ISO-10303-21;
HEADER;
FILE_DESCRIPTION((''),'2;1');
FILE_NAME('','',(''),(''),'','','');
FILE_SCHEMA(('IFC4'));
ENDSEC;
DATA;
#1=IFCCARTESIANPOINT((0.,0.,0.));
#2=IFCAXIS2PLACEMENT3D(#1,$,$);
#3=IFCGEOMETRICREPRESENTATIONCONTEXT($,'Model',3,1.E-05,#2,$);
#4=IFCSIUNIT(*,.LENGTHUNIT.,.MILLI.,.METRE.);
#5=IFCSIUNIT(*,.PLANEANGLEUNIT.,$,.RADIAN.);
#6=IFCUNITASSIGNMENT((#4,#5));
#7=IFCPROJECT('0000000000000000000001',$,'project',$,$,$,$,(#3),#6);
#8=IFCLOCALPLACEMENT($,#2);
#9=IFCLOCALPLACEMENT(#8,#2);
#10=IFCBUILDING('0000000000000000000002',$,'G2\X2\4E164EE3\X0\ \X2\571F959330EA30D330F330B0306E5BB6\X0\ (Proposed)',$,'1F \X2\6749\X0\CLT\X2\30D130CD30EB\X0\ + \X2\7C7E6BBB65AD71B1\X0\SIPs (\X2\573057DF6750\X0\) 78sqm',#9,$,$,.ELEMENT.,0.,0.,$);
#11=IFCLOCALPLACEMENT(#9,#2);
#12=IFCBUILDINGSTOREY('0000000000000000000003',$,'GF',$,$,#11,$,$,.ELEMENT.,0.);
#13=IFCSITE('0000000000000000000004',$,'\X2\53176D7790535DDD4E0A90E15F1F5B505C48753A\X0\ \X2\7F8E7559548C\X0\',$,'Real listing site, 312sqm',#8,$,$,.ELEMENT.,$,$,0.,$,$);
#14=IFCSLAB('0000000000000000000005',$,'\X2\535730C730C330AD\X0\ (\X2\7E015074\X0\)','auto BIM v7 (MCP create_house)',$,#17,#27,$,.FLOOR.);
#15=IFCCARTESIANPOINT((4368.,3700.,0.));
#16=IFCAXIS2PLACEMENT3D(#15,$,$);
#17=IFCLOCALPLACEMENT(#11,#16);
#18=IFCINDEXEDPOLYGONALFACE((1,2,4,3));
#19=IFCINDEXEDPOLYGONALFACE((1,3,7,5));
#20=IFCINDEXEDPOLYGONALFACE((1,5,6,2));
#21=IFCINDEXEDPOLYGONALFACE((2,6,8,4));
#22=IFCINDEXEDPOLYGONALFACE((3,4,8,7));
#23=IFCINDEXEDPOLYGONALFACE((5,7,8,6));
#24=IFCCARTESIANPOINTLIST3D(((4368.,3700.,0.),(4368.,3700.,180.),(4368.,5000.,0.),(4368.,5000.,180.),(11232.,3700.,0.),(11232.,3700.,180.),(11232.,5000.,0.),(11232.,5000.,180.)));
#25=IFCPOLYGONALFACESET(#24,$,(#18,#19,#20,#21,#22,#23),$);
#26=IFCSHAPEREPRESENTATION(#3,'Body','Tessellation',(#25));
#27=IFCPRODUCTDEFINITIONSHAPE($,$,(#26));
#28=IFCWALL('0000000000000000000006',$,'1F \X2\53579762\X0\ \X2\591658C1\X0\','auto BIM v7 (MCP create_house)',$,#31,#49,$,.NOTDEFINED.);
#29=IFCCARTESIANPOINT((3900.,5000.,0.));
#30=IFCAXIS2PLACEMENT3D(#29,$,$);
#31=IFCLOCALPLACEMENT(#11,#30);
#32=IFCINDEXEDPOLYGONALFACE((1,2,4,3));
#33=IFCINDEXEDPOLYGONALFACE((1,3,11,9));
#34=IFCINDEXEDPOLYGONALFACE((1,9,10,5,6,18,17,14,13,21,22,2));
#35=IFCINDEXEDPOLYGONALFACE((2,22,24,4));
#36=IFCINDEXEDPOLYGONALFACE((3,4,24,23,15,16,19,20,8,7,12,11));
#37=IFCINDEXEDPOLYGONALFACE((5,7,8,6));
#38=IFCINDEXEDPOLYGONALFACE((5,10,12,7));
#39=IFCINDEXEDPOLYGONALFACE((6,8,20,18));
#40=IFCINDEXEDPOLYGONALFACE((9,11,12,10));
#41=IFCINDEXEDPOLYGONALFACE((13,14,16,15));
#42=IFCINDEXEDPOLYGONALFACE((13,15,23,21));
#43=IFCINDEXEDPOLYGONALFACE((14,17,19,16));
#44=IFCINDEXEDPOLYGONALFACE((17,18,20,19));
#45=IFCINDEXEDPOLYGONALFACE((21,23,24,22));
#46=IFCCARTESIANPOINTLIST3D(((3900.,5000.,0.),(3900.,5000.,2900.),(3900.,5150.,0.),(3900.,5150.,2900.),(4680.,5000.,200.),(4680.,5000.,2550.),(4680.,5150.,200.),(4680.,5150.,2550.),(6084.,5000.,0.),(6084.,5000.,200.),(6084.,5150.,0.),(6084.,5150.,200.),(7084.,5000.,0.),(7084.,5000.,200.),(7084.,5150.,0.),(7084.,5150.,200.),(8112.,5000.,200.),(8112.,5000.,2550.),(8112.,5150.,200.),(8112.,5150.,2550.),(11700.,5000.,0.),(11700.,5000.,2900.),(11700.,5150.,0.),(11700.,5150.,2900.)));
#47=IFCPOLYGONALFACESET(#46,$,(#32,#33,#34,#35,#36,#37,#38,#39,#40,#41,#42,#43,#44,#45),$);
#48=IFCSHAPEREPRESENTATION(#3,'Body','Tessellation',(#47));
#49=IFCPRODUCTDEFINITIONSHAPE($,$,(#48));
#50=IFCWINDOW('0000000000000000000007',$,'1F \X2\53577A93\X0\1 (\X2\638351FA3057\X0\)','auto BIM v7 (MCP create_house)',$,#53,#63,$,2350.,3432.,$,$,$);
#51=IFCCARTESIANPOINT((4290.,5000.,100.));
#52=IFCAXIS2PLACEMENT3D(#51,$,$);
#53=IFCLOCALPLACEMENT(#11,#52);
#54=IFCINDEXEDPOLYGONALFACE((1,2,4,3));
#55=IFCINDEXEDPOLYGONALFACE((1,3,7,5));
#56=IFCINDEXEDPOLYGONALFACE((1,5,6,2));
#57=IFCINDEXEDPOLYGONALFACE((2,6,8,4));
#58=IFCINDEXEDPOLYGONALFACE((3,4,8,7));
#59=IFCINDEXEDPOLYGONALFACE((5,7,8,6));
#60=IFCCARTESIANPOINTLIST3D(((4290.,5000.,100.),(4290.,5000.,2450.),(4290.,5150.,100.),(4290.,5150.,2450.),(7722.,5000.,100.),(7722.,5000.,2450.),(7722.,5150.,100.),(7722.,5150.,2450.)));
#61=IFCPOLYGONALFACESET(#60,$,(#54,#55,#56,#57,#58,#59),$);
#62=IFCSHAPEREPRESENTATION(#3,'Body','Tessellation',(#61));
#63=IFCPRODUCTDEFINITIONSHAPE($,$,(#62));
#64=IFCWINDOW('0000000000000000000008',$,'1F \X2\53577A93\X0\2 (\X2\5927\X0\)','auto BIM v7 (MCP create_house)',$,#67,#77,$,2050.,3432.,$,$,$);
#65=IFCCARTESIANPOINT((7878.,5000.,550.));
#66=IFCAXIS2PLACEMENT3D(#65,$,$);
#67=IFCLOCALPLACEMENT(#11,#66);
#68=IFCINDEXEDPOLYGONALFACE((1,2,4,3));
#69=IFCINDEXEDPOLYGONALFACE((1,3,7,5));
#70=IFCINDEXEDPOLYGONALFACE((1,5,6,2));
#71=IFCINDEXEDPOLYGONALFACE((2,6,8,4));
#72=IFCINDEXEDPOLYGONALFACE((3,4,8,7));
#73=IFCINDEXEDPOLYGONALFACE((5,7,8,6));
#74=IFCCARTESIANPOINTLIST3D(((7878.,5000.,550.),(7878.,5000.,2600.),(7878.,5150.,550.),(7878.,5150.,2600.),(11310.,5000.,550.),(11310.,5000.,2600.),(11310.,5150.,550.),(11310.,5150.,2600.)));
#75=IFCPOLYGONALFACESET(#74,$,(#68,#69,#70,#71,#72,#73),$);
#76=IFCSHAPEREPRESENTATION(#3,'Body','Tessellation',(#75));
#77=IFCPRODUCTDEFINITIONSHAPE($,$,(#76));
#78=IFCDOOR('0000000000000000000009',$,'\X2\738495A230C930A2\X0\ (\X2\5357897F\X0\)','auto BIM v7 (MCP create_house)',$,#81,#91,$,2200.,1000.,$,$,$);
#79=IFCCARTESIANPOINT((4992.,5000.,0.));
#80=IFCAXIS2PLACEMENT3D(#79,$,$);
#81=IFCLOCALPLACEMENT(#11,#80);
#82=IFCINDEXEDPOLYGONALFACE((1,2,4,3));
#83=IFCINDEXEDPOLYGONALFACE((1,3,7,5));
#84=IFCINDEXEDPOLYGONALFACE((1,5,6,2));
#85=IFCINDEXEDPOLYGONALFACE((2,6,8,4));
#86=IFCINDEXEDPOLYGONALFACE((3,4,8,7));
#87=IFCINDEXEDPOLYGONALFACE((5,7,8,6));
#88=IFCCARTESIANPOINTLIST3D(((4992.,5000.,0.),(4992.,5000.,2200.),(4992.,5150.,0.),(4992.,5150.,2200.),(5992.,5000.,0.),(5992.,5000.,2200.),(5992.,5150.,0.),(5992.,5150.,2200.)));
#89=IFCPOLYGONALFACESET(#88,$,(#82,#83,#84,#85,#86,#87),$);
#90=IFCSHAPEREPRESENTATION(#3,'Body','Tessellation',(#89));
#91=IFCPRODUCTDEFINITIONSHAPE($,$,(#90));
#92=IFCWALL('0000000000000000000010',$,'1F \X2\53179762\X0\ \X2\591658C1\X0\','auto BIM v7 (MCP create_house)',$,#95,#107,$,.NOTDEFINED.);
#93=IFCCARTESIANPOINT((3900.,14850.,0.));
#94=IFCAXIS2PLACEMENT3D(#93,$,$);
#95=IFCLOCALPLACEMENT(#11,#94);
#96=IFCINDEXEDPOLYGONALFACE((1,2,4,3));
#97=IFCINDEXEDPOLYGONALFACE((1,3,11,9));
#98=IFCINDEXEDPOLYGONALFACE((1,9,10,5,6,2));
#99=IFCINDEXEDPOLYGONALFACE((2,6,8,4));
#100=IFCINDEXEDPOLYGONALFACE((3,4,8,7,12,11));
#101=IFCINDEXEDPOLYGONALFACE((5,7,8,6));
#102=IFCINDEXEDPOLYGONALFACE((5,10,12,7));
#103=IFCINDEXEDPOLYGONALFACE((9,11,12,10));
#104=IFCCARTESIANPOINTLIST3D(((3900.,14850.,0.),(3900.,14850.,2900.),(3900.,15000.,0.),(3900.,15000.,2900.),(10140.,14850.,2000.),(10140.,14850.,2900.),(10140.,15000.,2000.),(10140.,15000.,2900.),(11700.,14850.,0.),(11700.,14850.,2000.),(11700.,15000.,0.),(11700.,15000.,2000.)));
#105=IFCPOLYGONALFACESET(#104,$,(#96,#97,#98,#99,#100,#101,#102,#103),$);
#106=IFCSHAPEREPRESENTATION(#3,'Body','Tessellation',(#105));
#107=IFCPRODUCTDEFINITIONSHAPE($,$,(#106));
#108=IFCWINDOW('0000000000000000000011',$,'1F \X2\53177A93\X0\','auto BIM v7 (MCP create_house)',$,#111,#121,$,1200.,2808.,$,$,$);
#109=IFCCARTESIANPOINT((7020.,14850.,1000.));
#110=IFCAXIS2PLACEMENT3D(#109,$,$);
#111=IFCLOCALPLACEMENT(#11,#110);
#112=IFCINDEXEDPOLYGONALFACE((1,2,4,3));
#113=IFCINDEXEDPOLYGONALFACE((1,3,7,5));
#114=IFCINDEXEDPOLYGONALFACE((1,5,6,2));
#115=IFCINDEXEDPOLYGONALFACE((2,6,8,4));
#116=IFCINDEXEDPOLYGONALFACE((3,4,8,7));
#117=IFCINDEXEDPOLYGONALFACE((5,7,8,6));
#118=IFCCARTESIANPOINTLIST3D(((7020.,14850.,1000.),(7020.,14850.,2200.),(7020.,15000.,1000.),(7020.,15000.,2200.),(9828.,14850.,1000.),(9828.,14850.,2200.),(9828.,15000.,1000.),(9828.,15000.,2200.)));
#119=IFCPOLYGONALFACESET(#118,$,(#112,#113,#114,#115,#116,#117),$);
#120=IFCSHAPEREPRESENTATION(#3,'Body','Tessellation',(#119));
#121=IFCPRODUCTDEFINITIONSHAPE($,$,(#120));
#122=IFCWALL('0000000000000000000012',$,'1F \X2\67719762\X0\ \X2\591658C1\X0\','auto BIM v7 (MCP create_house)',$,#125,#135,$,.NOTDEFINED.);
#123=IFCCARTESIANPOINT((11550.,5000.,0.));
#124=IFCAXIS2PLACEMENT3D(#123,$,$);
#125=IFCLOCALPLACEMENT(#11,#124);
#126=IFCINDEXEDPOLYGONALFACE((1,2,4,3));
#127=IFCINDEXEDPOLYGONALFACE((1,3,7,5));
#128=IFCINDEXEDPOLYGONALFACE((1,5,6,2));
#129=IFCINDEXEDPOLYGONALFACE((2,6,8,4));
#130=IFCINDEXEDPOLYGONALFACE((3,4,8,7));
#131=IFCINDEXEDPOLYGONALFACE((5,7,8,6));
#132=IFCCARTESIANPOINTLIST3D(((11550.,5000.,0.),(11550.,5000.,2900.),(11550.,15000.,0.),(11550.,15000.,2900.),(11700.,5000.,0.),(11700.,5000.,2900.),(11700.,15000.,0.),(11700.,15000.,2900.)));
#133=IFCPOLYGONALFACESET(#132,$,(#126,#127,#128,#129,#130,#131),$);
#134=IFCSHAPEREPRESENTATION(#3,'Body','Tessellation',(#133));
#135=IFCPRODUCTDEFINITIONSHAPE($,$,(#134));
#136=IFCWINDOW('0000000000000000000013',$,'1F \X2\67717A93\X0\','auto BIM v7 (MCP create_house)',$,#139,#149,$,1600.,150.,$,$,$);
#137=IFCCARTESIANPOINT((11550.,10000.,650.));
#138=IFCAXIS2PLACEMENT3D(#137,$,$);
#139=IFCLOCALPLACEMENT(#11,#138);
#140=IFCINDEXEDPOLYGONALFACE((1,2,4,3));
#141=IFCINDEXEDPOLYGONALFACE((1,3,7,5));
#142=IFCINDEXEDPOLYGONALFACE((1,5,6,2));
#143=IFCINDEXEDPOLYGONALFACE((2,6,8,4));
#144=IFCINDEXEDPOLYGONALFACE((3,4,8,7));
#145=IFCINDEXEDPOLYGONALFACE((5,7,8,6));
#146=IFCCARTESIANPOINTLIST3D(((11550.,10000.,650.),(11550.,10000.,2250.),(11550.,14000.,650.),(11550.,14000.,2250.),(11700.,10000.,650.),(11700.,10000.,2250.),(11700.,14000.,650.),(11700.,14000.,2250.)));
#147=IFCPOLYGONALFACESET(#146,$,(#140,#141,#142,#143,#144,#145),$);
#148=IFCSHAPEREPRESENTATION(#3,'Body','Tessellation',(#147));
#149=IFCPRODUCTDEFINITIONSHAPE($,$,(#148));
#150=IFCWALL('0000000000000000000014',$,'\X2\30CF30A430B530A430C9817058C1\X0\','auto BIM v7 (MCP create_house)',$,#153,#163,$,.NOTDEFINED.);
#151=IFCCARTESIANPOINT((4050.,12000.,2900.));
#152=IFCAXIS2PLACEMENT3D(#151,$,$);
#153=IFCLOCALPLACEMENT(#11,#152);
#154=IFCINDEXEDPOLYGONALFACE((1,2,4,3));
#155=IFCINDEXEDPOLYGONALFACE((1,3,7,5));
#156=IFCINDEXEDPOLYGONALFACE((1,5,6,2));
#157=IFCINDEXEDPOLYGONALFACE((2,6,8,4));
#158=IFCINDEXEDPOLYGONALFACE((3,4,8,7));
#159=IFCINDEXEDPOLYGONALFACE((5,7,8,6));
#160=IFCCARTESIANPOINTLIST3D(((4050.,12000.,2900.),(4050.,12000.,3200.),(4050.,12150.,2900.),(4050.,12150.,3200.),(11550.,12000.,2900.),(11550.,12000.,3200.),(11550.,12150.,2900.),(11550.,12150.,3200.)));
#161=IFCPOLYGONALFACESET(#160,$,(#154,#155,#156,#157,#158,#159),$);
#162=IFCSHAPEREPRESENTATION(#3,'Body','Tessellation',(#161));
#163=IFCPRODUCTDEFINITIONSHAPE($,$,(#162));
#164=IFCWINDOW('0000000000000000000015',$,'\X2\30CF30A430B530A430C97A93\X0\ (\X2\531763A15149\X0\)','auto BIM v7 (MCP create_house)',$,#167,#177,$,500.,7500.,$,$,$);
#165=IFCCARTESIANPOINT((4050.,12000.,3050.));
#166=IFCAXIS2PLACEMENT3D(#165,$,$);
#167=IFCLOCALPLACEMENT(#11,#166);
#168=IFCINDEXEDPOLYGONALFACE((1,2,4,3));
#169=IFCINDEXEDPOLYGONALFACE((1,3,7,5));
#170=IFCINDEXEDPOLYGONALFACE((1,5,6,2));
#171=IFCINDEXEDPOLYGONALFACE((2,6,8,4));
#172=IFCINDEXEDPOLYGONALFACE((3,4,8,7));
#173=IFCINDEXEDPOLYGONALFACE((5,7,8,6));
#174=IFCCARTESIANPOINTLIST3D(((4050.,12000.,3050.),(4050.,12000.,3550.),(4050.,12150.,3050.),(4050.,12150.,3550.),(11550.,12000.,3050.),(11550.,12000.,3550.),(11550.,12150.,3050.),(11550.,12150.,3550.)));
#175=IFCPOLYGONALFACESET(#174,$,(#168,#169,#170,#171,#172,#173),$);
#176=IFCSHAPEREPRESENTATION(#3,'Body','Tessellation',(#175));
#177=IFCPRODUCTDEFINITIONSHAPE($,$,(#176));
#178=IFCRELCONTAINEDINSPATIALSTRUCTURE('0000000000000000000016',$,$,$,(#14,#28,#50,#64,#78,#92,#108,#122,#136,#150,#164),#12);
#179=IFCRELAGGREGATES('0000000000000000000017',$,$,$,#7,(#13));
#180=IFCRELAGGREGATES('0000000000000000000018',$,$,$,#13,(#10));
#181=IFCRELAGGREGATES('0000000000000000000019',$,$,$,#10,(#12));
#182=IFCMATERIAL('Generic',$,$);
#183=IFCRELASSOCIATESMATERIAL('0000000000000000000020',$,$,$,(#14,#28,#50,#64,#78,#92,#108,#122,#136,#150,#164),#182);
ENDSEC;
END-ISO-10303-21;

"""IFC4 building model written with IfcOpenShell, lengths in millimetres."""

from ifc_helpers import new_model, si_unit, frame, frame_2d, origin, place, context, project, spatial, rectangle, extrude, material, element, fill, save


model = new_model("IFC4")

# Units and contexts
model_context = context("Model", 3, precision=1e-05, world=origin())
ifc_project = project(units=[si_unit("LENGTHUNIT", "METRE", prefix="MILLI"), si_unit("PLANEANGLEUNIT", "RADIAN")], contexts=[model_context])

# Site, building, storey
site_placement = place(None, origin())
site = spatial("IfcSite", under=ifc_project, at=site_placement, Name="北海道川上郡弟子屈町 美留和", ObjectType="Real listing site, 312sqm", CompositionType="ELEMENT", RefElevation=0.0)
building_placement = place(site_placement, origin())
building = spatial("IfcBuilding", under=site, at=building_placement, Name="G2世代 土間リビングの家 (Proposed)", ObjectType="1F 杉CLTパネル + 籾殻断熱SIPs (地域材) 78sqm", CompositionType="ELEMENT", ElevationOfRefHeight=0.0, ElevationOfTerrain=0.0)
storey_placement = place(building_placement, origin())
storey = spatial("IfcBuildingStorey", under=building, at=storey_placement, Name="GF", CompositionType="ELEMENT", Elevation=0.0)

# Slab
ifc_material = material(Name="Generic")
slab_1_placement = place(storey_placement, frame((4368.0, 3700.0, 0.0)))
element("IfcSlab", 1, at=slab_1_placement, inside=storey, material=ifc_material, Name="南デッキ (縁側)", Description="auto BIM v7 (MCP create_house)", PredefinedType="FLOOR", context=model_context, shape_type="SweptSolid", body=[
    extrude(rectangle(XDim=6864.0, YDim=1300.0, at=frame_2d((3432.0, 650.0))), frame((4368.0, 3700.0, 0.0)), (0.0, 0.0, 1.0), 180.0),
])

# Wall, openings, windows, door
wall_1_placement = place(storey_placement, frame((3900.0, 5000.0, 0.0)))
wall_1 = element("IfcWall", 2, at=wall_1_placement, inside=storey, material=ifc_material, Name="1F 南面 外壁", Description="auto BIM v7 (MCP create_house)", PredefinedType="NOTDEFINED", context=model_context, shape_type="SweptSolid", body=[
    extrude(rectangle(XDim=7800.0, YDim=150.0, at=frame_2d((3900.0, 75.0))), frame((3900.0, 5000.0, 0.0)), (0.0, 0.0, 1.0), 2900.0),
])
opening_1_placement = place(storey_placement, frame((4290.0, 5000.0, 100.0)))
opening_1 = element("IfcOpeningElement", 3, at=opening_1_placement, cuts=wall_1, PredefinedType="NOTDEFINED", context=model_context, shape_type="SweptSolid", body=[
    extrude(rectangle(XDim=3432.0, YDim=150.0, at=frame_2d((1716.0, 75.0))), frame((4290.0, 5000.0, 100.0)), (0.0, 0.0, 1.0), 2350.0),
])
opening_2_placement = place(storey_placement, frame((7878.0, 5000.0, 550.0)))
opening_2 = element("IfcOpeningElement", 4, at=opening_2_placement, cuts=wall_1, PredefinedType="NOTDEFINED", context=model_context, shape_type="SweptSolid", body=[
    extrude(rectangle(XDim=3432.0, YDim=150.0, at=frame_2d((1716.0, 75.0))), frame((7878.0, 5000.0, 550.0)), (0.0, 0.0, 1.0), 2050.0),
])
opening_3_placement = place(storey_placement, frame((4992.0, 5000.0, 0.0)))
opening_3 = element("IfcOpeningElement", 5, at=opening_3_placement, cuts=wall_1, PredefinedType="NOTDEFINED", context=model_context, shape_type="SweptSolid", body=[
    extrude(rectangle(XDim=1000.0, YDim=150.0, at=frame_2d((500.0, 75.0))), frame((4992.0, 5000.0, 0.0)), (0.0, 0.0, 1.0), 2200.0),
])
window_1_placement = place(storey_placement, frame((4290.0, 5000.0, 100.0)))
window_1 = element("IfcWindow", 6, at=window_1_placement, inside=storey, material=ifc_material, Name="1F 南窓1 (掃出し)", Description="auto BIM v7 (MCP create_house)", OverallHeight=2350.0, OverallWidth=3432.0, context=model_context, shape_type="SweptSolid", body=[
    extrude(rectangle(XDim=3432.0, YDim=150.0, at=frame_2d((1716.0, 75.0))), frame((4290.0, 5000.0, 100.0)), (0.0, 0.0, 1.0), 2350.0),
])
fill(opening_1, window_1)
window_2_placement = place(storey_placement, frame((7878.0, 5000.0, 550.0)))
window_2 = element("IfcWindow", 7, at=window_2_placement, inside=storey, material=ifc_material, Name="1F 南窓2 (大)", Description="auto BIM v7 (MCP create_house)", OverallHeight=2050.0, OverallWidth=3432.0, context=model_context, shape_type="SweptSolid", body=[
    extrude(rectangle(XDim=3432.0, YDim=150.0, at=frame_2d((1716.0, 75.0))), frame((7878.0, 5000.0, 550.0)), (0.0, 0.0, 1.0), 2050.0),
])
fill(opening_2, window_2)
door_placement = place(storey_placement, frame((4992.0, 5000.0, 0.0)))
door = element("IfcDoor", 8, at=door_placement, inside=storey, material=ifc_material, Name="玄関ドア (南西)", Description="auto BIM v7 (MCP create_house)", OverallHeight=2200.0, OverallWidth=1000.0, context=model_context, shape_type="SweptSolid", body=[
    extrude(rectangle(XDim=1000.0, YDim=150.0, at=frame_2d((500.0, 75.0))), frame((4992.0, 5000.0, 0.0)), (0.0, 0.0, 1.0), 2200.0),
])
fill(opening_3, door)

# Walls, openings, windows
wall_2_placement = place(storey_placement, frame((3900.0, 14850.0, 0.0)))
wall_2 = element("IfcWall", 9, at=wall_2_placement, inside=storey, material=ifc_material, Name="1F 北面 外壁", Description="auto BIM v7 (MCP create_house)", PredefinedType="NOTDEFINED", context=model_context, shape_type="SweptSolid", body=[
    extrude(rectangle(XDim=7800.0, YDim=150.0, at=frame_2d((3900.0, 75.0))), frame((3900.0, 14850.0, 0.0)), (0.0, 0.0, 1.0), 2900.0),
])
opening_4_placement = place(storey_placement, frame((7020.0, 14850.0, 1000.0)))
opening_4 = element("IfcOpeningElement", 10, at=opening_4_placement, cuts=wall_2, PredefinedType="NOTDEFINED", context=model_context, shape_type="SweptSolid", body=[
    extrude(rectangle(XDim=2808.0, YDim=150.0, at=frame_2d((1404.0, 75.0))), frame((7020.0, 14850.0, 1000.0)), (0.0, 0.0, 1.0), 1200.0),
])
window_3_placement = place(storey_placement, frame((7020.0, 14850.0, 1000.0)))
window_3 = element("IfcWindow", 11, at=window_3_placement, inside=storey, material=ifc_material, Name="1F 北窓", Description="auto BIM v7 (MCP create_house)", OverallHeight=1200.0, OverallWidth=2808.0, context=model_context, shape_type="SweptSolid", body=[
    extrude(rectangle(XDim=2808.0, YDim=150.0, at=frame_2d((1404.0, 75.0))), frame((7020.0, 14850.0, 1000.0)), (0.0, 0.0, 1.0), 1200.0),
])
fill(opening_4, window_3)
wall_3_placement = place(storey_placement, frame((11550.0, 5000.0, 0.0)))
wall_3 = element("IfcWall", 12, at=wall_3_placement, inside=storey, material=ifc_material, Name="1F 東面 外壁", Description="auto BIM v7 (MCP create_house)", PredefinedType="NOTDEFINED", context=model_context, shape_type="SweptSolid", body=[
    extrude(rectangle(XDim=150.0, YDim=10000.0, at=frame_2d((75.0, 5000.0))), frame((11550.0, 5000.0, 0.0)), (0.0, 0.0, 1.0), 2900.0),
])
opening_5_placement = place(storey_placement, frame((11550.0, 10000.0, 650.0)))
opening_5 = element("IfcOpeningElement", 13, at=opening_5_placement, cuts=wall_3, PredefinedType="NOTDEFINED", context=model_context, shape_type="SweptSolid", body=[
    extrude(rectangle(XDim=150.0, YDim=4000.0, at=frame_2d((75.0, 2000.0))), frame((11550.0, 10000.0, 650.0)), (0.0, 0.0, 1.0), 1600.0),
])
window_4_placement = place(storey_placement, frame((11550.0, 10000.0, 650.0)))
window_4 = element("IfcWindow", 14, at=window_4_placement, inside=storey, material=ifc_material, Name="1F 東窓", Description="auto BIM v7 (MCP create_house)", OverallHeight=1600.0, OverallWidth=150.0, context=model_context, shape_type="SweptSolid", body=[
    extrude(rectangle(XDim=150.0, YDim=4000.0, at=frame_2d((75.0, 2000.0))), frame((11550.0, 10000.0, 650.0)), (0.0, 0.0, 1.0), 1600.0),
])
fill(opening_5, window_4)

# Wall, opening, window
wall_4_placement = place(storey_placement, frame((4050.0, 12000.0, 2900.0)))
wall_4 = element("IfcWall", 15, at=wall_4_placement, inside=storey, material=ifc_material, Name="ハイサイド腰壁", Description="auto BIM v7 (MCP create_house)", PredefinedType="NOTDEFINED", context=model_context, shape_type="SweptSolid", body=[
    extrude(rectangle(XDim=7500.0, YDim=150.0, at=frame_2d((3750.0, 75.0))), frame((4050.0, 12000.0, 2900.0)), (0.0, 0.0, 1.0), 700.0),
])
opening_6_placement = place(storey_placement, frame((4050.0, 12000.0, 3050.0)))
opening_6 = element("IfcOpeningElement", 16, at=opening_6_placement, cuts=wall_4, PredefinedType="NOTDEFINED", context=model_context, shape_type="SweptSolid", body=[
    extrude(rectangle(XDim=7500.0, YDim=150.0, at=frame_2d((3750.0, 75.0))), frame((4050.0, 12000.0, 3050.0)), (0.0, 0.0, 1.0), 500.0),
])
window_5_placement = place(storey_placement, frame((4050.0, 12000.0, 3050.0)))
window_5 = element("IfcWindow", 17, at=window_5_placement, inside=storey, material=ifc_material, Name="ハイサイド窓 (北採光)", Description="auto BIM v7 (MCP create_house)", OverallHeight=500.0, OverallWidth=7500.0, context=model_context, shape_type="SweptSolid", body=[
    extrude(rectangle(XDim=7500.0, YDim=150.0, at=frame_2d((3750.0, 75.0))), frame((4050.0, 12000.0, 3050.0)), (0.0, 0.0, 1.0), 500.0),
])
fill(opening_6, window_5)

save(model, "model.ifc")
